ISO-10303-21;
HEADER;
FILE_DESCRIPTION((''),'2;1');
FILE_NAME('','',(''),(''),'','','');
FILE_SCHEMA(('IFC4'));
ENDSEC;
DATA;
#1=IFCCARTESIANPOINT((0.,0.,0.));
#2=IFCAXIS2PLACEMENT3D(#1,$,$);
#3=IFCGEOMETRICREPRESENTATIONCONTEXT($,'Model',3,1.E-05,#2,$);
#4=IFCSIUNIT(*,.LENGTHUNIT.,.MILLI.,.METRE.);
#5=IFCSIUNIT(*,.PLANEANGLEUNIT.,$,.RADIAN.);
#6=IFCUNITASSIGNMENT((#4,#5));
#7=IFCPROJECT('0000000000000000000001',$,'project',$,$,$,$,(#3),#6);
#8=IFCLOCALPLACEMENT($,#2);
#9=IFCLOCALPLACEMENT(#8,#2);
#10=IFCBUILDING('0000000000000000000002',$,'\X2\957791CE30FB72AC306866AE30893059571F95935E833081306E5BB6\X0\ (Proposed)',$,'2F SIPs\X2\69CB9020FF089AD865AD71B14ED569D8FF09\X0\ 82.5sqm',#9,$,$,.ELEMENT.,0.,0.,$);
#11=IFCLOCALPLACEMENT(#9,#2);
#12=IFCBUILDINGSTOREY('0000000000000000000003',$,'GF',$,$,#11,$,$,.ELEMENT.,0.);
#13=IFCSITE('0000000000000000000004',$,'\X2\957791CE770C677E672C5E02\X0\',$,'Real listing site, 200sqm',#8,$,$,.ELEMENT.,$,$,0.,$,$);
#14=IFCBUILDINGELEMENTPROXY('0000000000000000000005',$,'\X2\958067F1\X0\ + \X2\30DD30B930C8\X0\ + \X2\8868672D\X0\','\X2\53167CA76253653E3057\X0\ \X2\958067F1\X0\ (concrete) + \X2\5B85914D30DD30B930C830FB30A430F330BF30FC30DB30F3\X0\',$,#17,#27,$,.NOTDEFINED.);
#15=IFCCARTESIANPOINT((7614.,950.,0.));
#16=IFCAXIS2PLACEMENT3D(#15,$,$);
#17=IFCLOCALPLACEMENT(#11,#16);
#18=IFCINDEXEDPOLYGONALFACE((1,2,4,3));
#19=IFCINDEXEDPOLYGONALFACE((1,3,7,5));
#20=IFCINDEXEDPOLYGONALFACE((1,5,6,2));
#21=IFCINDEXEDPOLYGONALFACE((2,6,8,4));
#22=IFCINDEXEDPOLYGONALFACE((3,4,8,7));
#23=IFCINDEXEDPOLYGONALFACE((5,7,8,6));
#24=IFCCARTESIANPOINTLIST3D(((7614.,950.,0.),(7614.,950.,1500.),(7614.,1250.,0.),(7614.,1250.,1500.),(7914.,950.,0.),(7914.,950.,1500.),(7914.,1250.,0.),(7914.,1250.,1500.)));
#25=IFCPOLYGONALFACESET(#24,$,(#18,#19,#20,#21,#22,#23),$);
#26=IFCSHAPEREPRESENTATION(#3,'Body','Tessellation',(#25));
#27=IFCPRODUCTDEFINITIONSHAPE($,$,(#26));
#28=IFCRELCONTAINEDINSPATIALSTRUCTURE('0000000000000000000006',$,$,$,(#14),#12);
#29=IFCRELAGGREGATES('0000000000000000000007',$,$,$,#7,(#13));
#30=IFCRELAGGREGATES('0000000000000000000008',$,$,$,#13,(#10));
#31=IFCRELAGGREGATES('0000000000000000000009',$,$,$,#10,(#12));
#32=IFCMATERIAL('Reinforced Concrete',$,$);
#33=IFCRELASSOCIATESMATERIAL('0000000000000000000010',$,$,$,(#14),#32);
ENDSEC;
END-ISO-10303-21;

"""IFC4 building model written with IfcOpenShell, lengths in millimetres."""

from ifc_helpers import new_model, si_unit, frame, frame_2d, origin, place, context, project, spatial, rectangle, extrude, material, element, save


model = new_model("IFC4")

# Units and contexts
model_context = context("Model", 3, precision=1e-05, world=origin())
ifc_project = project(units=[si_unit("LENGTHUNIT", "METRE", prefix="MILLI"), si_unit("PLANEANGLEUNIT", "RADIAN")], contexts=[model_context])

# Site, building, storey
site_placement = place(None, origin())
site = spatial("IfcSite", under=ifc_project, at=site_placement, Name="長野県松本市", ObjectType="Real listing site, 200sqm", CompositionType="ELEMENT", RefElevation=0.0)
building_placement = place(site_placement, origin())
building = spatial("IfcBuilding", under=site, at=building_placement, Name="長野・犬と暮らす土間広めの家 (Proposed)", ObjectType="2F SIPs構造（高断熱仕様） 82.5sqm", CompositionType="ELEMENT", ElevationOfRefHeight=0.0, ElevationOfTerrain=0.0)
storey_placement = place(building_placement, origin())
storey = spatial("IfcBuildingStorey", under=building, at=storey_placement, Name="GF", CompositionType="ELEMENT", Elevation=0.0)

# Shared definitions
ifc_material_1 = material(Name="Reinforced Concrete")

# Building element proxy
proxy_placement = place(storey_placement, frame((7614.0, 950.0, 0.0)))
element("IfcBuildingElementProxy", 1, at=proxy_placement, inside=storey, material=ifc_material_1, Name="門柱 + ポスト + 表札", Description="化粧打放し 門柱 (concrete) + 宅配ポスト・インターホン", PredefinedType="NOTDEFINED", context=model_context, shape_type="SweptSolid", body=[
    extrude(rectangle(XDim=300.0, YDim=300.0, at=frame_2d((150.0, 150.0))), frame((7614.0, 950.0, 0.0)), (0.0, 0.0, 1.0), 1500.0),
])

save(model, "model.ifc")
